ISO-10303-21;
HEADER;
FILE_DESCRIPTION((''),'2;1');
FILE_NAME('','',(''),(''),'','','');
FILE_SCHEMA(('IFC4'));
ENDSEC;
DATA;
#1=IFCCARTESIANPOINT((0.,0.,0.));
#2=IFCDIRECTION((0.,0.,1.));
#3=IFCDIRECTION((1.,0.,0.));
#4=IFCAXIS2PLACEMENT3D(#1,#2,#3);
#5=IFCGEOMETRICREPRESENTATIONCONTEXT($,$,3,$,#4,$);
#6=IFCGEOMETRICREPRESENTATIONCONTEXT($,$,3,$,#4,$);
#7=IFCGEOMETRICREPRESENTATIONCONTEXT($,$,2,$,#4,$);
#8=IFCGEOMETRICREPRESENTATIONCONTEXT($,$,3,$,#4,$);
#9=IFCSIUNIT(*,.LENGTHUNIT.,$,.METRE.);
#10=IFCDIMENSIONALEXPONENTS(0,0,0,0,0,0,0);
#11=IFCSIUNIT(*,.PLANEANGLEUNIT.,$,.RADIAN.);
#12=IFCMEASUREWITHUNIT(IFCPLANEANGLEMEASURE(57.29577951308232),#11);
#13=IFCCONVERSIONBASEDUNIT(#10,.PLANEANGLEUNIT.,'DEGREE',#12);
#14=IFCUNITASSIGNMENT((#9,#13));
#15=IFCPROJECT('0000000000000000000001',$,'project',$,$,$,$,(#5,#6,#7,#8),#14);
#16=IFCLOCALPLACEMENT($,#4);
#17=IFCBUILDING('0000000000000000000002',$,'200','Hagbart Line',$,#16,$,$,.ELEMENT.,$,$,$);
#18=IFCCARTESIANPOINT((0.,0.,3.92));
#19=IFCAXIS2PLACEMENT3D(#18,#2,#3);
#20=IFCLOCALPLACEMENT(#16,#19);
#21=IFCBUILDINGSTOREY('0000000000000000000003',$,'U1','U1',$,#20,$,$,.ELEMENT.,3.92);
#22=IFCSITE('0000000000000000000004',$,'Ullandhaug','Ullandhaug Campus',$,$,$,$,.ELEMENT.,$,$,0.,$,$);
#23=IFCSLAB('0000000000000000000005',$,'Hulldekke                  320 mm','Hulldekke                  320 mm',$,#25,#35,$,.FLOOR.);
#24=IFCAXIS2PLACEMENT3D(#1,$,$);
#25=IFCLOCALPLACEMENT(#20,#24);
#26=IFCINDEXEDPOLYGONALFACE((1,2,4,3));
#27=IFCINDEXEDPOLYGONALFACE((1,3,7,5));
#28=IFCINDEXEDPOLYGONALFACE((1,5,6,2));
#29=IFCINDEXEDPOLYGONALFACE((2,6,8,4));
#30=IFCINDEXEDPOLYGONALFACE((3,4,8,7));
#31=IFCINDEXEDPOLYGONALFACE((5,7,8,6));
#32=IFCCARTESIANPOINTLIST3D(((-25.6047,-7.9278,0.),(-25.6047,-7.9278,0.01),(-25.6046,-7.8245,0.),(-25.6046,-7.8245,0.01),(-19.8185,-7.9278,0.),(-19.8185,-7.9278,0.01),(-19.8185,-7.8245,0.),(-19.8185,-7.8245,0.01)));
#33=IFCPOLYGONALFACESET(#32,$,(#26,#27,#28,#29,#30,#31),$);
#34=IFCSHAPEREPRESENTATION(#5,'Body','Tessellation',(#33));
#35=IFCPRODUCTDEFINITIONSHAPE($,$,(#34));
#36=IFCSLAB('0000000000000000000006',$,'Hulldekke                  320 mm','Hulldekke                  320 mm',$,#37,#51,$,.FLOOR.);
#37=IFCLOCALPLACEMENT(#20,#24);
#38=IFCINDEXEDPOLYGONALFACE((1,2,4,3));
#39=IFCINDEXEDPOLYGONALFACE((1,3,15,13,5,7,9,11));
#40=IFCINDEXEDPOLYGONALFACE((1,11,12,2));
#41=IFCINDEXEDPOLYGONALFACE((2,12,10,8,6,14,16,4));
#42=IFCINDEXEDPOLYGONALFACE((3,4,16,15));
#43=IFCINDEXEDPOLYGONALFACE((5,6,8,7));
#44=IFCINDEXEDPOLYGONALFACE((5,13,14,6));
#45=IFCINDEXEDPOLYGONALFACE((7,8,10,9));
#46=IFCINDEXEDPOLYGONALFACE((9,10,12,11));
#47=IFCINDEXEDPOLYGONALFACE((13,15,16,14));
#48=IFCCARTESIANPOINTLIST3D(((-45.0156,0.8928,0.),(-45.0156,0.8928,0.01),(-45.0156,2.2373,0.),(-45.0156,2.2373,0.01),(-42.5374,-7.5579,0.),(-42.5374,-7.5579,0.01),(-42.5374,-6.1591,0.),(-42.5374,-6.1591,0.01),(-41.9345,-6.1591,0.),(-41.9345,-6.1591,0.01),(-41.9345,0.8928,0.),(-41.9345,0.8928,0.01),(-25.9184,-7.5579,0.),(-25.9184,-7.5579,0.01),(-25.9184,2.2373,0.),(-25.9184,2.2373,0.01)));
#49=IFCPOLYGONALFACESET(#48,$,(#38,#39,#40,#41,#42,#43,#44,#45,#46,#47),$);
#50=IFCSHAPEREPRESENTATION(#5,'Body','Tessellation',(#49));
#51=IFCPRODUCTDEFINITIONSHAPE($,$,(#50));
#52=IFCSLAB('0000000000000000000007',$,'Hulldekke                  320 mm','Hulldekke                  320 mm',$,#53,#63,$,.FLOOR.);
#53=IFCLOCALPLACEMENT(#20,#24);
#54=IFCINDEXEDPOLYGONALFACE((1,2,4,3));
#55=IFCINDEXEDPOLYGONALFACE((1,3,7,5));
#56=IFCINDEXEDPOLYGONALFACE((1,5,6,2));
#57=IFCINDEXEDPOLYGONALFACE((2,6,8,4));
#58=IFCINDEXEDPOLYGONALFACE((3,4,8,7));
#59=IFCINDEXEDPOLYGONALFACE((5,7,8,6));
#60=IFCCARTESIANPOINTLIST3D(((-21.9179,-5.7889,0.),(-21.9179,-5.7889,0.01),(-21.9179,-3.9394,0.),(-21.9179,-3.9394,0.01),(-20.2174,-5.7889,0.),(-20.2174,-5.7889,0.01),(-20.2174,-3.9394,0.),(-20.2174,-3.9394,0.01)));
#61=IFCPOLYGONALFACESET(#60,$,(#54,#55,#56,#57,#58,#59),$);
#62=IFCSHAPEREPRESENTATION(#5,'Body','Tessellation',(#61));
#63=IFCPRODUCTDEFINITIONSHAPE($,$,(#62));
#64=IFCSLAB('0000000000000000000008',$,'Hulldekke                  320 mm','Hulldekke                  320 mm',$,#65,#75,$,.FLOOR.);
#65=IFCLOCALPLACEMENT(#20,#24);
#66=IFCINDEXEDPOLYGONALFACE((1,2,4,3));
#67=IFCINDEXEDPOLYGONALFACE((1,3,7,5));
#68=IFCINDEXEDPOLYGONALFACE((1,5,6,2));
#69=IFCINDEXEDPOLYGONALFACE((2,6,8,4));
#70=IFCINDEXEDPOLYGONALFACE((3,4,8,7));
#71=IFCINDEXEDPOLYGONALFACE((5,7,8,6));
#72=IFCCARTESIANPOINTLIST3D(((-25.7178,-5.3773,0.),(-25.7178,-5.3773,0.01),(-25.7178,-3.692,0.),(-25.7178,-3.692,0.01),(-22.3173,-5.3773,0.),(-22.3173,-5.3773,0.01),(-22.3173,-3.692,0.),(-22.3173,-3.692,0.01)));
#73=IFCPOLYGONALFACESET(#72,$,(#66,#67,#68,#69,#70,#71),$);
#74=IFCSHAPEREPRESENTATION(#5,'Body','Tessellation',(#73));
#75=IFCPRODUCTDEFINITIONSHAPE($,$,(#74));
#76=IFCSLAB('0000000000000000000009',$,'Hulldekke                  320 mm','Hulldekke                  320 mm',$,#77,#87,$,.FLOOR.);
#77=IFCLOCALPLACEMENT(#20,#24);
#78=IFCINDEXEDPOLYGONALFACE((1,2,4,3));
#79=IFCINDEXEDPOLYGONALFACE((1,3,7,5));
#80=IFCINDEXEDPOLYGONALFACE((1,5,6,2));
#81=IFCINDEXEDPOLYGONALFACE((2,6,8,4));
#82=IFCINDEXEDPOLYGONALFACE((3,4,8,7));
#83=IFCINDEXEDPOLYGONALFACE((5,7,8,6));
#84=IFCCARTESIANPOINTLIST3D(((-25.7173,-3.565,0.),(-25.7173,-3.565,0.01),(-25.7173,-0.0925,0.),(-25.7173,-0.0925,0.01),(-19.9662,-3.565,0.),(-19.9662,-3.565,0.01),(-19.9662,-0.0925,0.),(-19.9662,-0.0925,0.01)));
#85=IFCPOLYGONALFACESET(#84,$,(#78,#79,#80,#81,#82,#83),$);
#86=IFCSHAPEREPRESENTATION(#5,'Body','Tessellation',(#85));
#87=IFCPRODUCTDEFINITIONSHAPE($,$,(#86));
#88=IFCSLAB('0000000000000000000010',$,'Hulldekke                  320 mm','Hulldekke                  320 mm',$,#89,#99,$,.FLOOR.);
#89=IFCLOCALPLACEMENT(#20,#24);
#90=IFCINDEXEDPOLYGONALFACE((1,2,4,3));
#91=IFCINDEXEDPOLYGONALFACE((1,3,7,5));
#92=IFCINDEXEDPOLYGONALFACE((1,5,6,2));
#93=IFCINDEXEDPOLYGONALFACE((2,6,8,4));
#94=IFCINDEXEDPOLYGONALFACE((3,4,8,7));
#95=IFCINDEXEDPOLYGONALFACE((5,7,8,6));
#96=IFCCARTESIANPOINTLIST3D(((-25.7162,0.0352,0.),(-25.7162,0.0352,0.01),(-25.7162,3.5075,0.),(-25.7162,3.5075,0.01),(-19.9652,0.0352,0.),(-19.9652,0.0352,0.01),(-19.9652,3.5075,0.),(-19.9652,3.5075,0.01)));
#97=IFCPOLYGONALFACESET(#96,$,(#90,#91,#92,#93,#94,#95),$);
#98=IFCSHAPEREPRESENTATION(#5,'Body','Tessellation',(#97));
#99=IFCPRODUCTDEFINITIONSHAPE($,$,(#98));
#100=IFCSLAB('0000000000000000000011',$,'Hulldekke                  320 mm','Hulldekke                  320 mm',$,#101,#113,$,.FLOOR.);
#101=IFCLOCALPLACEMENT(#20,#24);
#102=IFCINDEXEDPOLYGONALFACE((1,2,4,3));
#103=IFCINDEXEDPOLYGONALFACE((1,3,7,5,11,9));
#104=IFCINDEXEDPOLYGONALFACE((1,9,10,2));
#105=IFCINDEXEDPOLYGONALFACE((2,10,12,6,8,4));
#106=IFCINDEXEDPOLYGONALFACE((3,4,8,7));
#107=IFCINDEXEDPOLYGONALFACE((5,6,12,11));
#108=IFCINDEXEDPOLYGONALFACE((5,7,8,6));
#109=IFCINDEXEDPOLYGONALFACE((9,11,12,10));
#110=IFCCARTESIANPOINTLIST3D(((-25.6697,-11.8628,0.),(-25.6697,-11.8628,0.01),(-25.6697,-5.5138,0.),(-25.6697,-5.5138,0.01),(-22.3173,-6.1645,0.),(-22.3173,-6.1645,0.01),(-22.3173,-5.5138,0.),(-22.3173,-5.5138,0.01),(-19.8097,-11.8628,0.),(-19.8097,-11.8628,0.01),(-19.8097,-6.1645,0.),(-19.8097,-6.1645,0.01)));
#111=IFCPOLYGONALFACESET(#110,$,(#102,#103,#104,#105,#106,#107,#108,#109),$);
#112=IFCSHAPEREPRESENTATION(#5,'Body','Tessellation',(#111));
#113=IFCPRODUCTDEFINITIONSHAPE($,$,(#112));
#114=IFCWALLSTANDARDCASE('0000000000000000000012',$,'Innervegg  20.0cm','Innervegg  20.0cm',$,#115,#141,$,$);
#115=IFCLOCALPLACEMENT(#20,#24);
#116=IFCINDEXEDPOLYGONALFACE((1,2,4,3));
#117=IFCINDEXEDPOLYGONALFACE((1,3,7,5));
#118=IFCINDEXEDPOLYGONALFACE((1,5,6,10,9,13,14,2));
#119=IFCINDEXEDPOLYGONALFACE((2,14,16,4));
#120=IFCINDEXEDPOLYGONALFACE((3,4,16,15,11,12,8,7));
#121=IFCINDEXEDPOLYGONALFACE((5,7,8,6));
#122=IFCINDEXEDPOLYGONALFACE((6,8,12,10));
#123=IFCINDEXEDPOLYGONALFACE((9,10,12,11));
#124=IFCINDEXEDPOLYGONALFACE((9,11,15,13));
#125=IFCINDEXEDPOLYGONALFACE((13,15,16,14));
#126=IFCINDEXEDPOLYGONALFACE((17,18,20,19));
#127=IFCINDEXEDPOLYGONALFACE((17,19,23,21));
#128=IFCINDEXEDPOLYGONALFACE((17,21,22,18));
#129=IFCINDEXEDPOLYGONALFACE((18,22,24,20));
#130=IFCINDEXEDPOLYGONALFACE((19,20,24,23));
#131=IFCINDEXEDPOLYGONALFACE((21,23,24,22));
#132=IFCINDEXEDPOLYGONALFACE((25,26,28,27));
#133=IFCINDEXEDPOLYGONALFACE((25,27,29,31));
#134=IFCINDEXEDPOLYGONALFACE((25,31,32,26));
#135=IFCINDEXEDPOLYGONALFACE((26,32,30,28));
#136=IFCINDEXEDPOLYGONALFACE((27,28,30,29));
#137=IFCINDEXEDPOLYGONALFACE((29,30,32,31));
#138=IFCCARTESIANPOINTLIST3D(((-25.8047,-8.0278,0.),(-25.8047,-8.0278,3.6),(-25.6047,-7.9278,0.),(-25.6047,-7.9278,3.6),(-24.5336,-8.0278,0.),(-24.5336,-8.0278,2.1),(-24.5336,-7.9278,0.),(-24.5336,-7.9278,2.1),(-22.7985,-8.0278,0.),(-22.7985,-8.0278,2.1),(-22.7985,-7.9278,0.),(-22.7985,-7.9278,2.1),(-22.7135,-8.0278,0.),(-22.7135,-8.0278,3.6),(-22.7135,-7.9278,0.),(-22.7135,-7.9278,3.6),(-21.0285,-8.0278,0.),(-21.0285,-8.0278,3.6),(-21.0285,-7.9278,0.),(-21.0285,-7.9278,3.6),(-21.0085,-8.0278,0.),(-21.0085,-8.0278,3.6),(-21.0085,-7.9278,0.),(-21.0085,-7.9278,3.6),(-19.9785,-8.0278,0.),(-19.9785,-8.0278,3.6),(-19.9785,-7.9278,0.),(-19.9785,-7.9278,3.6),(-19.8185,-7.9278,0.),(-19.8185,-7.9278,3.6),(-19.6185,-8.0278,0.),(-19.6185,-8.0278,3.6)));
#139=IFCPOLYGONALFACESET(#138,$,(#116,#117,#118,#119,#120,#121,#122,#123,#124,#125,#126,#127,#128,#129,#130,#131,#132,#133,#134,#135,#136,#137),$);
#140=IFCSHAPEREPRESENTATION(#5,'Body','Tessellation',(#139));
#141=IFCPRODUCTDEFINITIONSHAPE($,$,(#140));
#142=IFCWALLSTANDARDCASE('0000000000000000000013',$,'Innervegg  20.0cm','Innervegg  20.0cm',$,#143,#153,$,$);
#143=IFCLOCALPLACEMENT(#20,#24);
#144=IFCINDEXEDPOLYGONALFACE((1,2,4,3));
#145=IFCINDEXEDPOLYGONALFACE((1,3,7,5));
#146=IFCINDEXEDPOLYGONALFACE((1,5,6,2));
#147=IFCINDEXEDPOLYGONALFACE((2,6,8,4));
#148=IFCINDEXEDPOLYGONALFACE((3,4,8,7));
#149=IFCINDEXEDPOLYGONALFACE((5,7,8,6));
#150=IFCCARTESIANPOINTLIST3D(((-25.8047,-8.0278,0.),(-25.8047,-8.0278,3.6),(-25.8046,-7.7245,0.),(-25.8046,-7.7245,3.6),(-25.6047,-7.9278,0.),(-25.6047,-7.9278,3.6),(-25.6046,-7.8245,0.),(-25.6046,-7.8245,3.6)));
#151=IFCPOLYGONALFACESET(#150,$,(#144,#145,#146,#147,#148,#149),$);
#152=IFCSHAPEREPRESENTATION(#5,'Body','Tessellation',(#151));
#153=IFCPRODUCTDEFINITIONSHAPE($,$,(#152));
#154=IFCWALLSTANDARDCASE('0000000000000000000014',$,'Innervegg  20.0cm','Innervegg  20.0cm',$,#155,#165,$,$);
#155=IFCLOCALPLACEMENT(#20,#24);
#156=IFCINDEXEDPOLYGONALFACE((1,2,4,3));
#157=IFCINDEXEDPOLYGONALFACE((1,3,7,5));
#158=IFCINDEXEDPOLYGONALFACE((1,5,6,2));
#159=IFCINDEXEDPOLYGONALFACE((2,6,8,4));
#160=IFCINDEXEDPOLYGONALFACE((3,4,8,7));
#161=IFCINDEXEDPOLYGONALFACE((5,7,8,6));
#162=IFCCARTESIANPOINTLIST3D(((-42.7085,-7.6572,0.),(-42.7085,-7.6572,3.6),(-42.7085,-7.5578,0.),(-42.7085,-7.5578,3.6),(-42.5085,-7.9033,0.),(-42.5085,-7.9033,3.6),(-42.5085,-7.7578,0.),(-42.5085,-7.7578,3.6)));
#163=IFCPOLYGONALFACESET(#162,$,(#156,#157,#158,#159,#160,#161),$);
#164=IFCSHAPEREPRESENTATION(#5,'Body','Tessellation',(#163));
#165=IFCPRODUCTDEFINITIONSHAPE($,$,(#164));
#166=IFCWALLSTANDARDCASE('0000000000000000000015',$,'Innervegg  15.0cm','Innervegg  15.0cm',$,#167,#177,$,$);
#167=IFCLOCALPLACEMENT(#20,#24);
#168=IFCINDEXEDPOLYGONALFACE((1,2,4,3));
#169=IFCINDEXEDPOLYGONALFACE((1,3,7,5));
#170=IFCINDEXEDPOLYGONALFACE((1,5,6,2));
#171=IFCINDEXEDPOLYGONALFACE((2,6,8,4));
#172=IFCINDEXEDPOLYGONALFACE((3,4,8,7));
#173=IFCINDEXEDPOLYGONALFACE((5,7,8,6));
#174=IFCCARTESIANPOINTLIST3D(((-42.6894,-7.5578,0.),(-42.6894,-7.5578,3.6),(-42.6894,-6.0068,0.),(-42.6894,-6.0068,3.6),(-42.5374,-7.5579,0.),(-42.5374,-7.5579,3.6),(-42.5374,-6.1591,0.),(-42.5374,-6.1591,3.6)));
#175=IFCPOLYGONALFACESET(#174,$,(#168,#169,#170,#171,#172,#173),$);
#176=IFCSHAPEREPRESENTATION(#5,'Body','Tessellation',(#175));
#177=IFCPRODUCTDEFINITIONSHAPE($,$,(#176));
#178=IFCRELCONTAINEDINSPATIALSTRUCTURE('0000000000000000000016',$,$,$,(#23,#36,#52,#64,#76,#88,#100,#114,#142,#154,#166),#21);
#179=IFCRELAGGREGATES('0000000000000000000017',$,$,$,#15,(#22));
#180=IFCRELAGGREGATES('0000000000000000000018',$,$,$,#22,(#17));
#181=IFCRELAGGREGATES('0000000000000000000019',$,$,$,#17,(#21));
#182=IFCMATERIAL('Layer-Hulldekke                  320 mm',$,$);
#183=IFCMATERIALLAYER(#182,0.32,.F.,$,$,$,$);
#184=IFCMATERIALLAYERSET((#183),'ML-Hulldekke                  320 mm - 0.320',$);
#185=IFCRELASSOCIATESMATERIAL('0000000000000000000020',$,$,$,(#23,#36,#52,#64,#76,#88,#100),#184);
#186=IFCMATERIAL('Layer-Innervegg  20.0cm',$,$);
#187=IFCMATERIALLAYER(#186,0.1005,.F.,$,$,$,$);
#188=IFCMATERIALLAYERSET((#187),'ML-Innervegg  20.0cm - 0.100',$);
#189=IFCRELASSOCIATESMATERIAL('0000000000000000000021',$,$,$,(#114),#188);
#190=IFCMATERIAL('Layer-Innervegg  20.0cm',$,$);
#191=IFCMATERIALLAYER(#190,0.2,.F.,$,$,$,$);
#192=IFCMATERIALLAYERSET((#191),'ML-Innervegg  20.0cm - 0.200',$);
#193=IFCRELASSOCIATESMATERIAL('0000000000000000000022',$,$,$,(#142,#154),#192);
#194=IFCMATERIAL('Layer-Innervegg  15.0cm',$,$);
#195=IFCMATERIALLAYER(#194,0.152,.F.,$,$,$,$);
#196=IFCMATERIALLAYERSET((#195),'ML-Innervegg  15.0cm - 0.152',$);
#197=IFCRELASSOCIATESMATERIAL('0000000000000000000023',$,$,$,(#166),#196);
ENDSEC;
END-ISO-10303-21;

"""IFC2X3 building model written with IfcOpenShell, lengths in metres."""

from ifc_helpers import new_model, entity, si_unit, converted_unit, frame, origin_with_axes, place, context, project, spatial, polyline, outline, extrude, material, layer, layer_set, layer_usage, element, save


model = new_model("IFC2X3")

# Units and contexts
context_of_model_1 = context(None, 3, world=origin_with_axes())
context_of_model_2 = context(None, 3, world=origin_with_axes())
context_of_model_3 = context(None, 2, world=origin_with_axes())
context_of_model_4 = context(None, 3, world=origin_with_axes())
ifc_project = project(units=[si_unit("LENGTHUNIT", "METRE"), converted_unit("PLANEANGLEUNIT", "DEGREE", entity("IfcPlaneAngleMeasure", 57.29577951308232), si_unit("PLANEANGLEUNIT", "RADIAN"), dimensions=[0, 0, 0, 0, 0, 0, 0])], contexts=[context_of_model_1, context_of_model_2, context_of_model_3, context_of_model_4])

# Site, building, storey
site = spatial("IfcSite", under=ifc_project, Name="Ullandhaug", Description="Ullandhaug Campus", CompositionType="ELEMENT", RefElevation=0.0)
building_placement = place(None, origin_with_axes())
building = spatial("IfcBuilding", under=site, at=building_placement, Name="200", Description="Hagbart Line", CompositionType="ELEMENT")
storey_placement = place(building_placement, frame((0.0, 0.0, 3.92), z_axis=(0.0, 0.0, 1.0), x_axis=(1.0, 0.0, 0.0)))
storey = spatial("IfcBuildingStorey", under=building, at=storey_placement, Name="U1", Description="U1", CompositionType="ELEMENT", Elevation=3.92)

# Slabs
ifc_material_1 = material(Name="Layer-Hulldekke                  320 mm")
ifc_layer_1 = layer(ifc_material_1, 0.32, ventilated=False)
ifc_layer_set_1 = layer_set([ifc_layer_1], Name="ML-Hulldekke                  320 mm - 0.320")
ifc_layer_usage_1 = layer_usage(ifc_layer_set_1, "AXIS2", "POSITIVE", 0.0)
slab_1_placement = place(storey_placement, frame((-25.6047, -7.9278, 0.0), z_axis=(0.0, 0.0, 1.0), x_axis=(1.0, 0.0, 0.0)))
element("IfcSlab", 1, at=slab_1_placement, inside=storey, material=ifc_layer_usage_1, Name="Hulldekke                  320 mm", Description="Hulldekke                  320 mm", PredefinedType="FLOOR", context=context_of_model_1, shape_type="SweptSolid", body=[
    extrude(outline(polyline([(0.0, 0.0), (5.7861, 0.0), (5.7861, 0.1033), (0.0, 0.1033), (0.0, 0.0)])), origin_with_axes(), (0.0, 0.0, 1.0), 0.01),
])
slab_2_placement = place(storey_placement, frame((-42.5374, -7.5579, 0.0), z_axis=(0.0, 0.0, 1.0), x_axis=(1.0, 0.0, 0.0)))
element("IfcSlab", 2, at=slab_2_placement, inside=storey, material=ifc_layer_usage_1, Name="Hulldekke                  320 mm", Description="Hulldekke                  320 mm", PredefinedType="FLOOR", context=context_of_model_1, shape_type="SweptSolid", body=[
    extrude(outline(polyline([(0.0, 0.0), (16.619, 0.0), (16.619, 9.7952), (-2.4781, 9.7952), (-2.4781, 8.4507), (0.603, 8.4507), (0.603, 1.3988), (0.0, 1.3988), (0.0, 0.0)])), origin_with_axes(), (0.0, 0.0, 1.0), 0.01),
])
slab_3_placement = place(storey_placement, frame((-21.9179, -5.7889, 0.0), z_axis=(0.0, 0.0, 1.0), x_axis=(1.0, 0.0, 0.0)))
element("IfcSlab", 3, at=slab_3_placement, inside=storey, material=ifc_layer_usage_1, Name="Hulldekke                  320 mm", Description="Hulldekke                  320 mm", PredefinedType="FLOOR", context=context_of_model_1, shape_type="SweptSolid", body=[
    extrude(outline(polyline([(0.0, 0.0), (1.7005, 0.0), (1.7005, 1.8495), (0.0, 1.8495), (0.0, 0.0)])), origin_with_axes(), (0.0, 0.0, 1.0), 0.01),
])
slab_4_placement = place(storey_placement, frame((-25.7178, -5.3773, 0.0), z_axis=(0.0, 0.0, 1.0), x_axis=(1.0, 0.0, 0.0)))
element("IfcSlab", 4, at=slab_4_placement, inside=storey, material=ifc_layer_usage_1, Name="Hulldekke                  320 mm", Description="Hulldekke                  320 mm", PredefinedType="FLOOR", context=context_of_model_1, shape_type="SweptSolid", body=[
    extrude(outline(polyline([(0.0, 0.0), (3.4005, 0.0), (3.4005, 1.6853), (0.0, 1.6853), (0.0, 0.0)])), origin_with_axes(), (0.0, 0.0, 1.0), 0.01),
])
slab_5_placement = place(storey_placement, frame((-25.7173, -3.565, 0.0), z_axis=(0.0, 0.0, 1.0), x_axis=(1.0, 0.0, 0.0)))
element("IfcSlab", 5, at=slab_5_placement, inside=storey, material=ifc_layer_usage_1, Name="Hulldekke                  320 mm", Description="Hulldekke                  320 mm", PredefinedType="FLOOR", context=context_of_model_1, shape_type="SweptSolid", body=[
    extrude(outline(polyline([(0.0, 0.0), (5.751, 0.0), (5.751, 3.4726), (0.0, 3.4726), (0.0, 0.0)])), origin_with_axes(), (0.0, 0.0, 1.0), 0.01),
])
slab_6_placement = place(storey_placement, frame((-25.7162, 0.0352, 0.0), z_axis=(0.0, 0.0, 1.0), x_axis=(1.0, 0.0, 0.0)))
element("IfcSlab", 6, at=slab_6_placement, inside=storey, material=ifc_layer_usage_1, Name="Hulldekke                  320 mm", Description="Hulldekke                  320 mm", PredefinedType="FLOOR", context=context_of_model_1, shape_type="SweptSolid", body=[
    extrude(outline(polyline([(0.0, 0.0), (5.751, 0.0), (5.751, 3.4723), (0.0, 3.4723), (0.0, 0.0)])), origin_with_axes(), (0.0, 0.0, 1.0), 0.01),
])
slab_7_placement = place(storey_placement, frame((-25.6697, -11.8628, 0.0), z_axis=(0.0, 0.0, 1.0), x_axis=(1.0, 0.0, 0.0)))
element("IfcSlab", 7, at=slab_7_placement, inside=storey, material=ifc_layer_usage_1, Name="Hulldekke                  320 mm", Description="Hulldekke                  320 mm", PredefinedType="FLOOR", context=context_of_model_1, shape_type="SweptSolid", body=[
    extrude(outline(polyline([(0.0, 0.0), (5.86, 0.0), (5.86, 5.6983), (3.3524, 5.6983), (3.3524, 6.349), (0.0, 6.349), (0.0, 0.0)])), origin_with_axes(), (0.0, 0.0, 1.0), 0.01),
])

# Wall, openings
ifc_material_2 = material(Name="Layer-Innervegg  20.0cm")
ifc_layer_2 = layer(ifc_material_2, 0.1005, ventilated=False)
ifc_layer_set_2 = layer_set([ifc_layer_2], Name="ML-Innervegg  20.0cm - 0.100")
ifc_layer_usage_2 = layer_usage(ifc_layer_set_2, "AXIS2", "POSITIVE", 0.0)
wall_1_placement = place(storey_placement, frame((-25.8047, -8.0278, 0.0), z_axis=(0.0, 0.0, 1.0), x_axis=(1.0, 0.0, 0.0)))
wall_1 = element("IfcWallStandardCase", 8, at=wall_1_placement, inside=storey, material=ifc_layer_usage_2, Name="Innervegg  20.0cm", Description="Innervegg  20.0cm", context=context_of_model_1, shape_type="SweptSolid", body=[
    extrude(outline(polyline([(0.0, 0.0), (6.1862, 0.0), (5.9862, 0.1), (0.2, 0.1), (0.0, 0.0)])), origin_with_axes(), (0.0, 0.0, 1.0), 3.6),
])
opening_1_placement = place(wall_1_placement, frame((1.2711, 0.1, 0.0), z_axis=(0.0, 0.0, 1.0), x_axis=(1.0, 0.0, 0.0)))
element("IfcOpeningElement", 9, at=opening_1_placement, cuts=wall_1, context=context_of_model_1, shape_type="SweptSolid", body=[
    extrude(outline(polyline([(0.0, 0.0), (2.1, 0.0), (2.1, 1.735), (0.0, 1.735), (0.0, 0.0)])), frame((0.0, 0.0, 0.0), z_axis=(0.0, 1.0, 0.0), x_axis=(0.0, 0.0, 1.0)), (0.0, 0.0, -1.0), 0.1),
])
opening_2_placement = place(wall_1_placement, frame((4.7962, 0.1, 0.0), z_axis=(0.0, 0.0, 1.0), x_axis=(1.0, 0.0, 0.0)))
element("IfcOpeningElement", 10, at=opening_2_placement, cuts=wall_1, context=context_of_model_1, shape_type="SweptSolid", body=[
    extrude(outline(polyline([(0.0, 0.0), (3.6, 0.0), (3.6, 1.03), (0.0, 1.03), (0.0, 0.0)])), frame((0.0, 0.0, 0.0), z_axis=(0.0, 1.0, 0.0), x_axis=(0.0, 0.0, 1.0)), (0.0, 0.0, -1.0), 0.1),
])
opening_3_placement = place(wall_1_placement, frame((3.0912, 0.1, 0.0), z_axis=(0.0, 0.0, 1.0), x_axis=(1.0, 0.0, 0.0)))
element("IfcOpeningElement", 11, at=opening_3_placement, cuts=wall_1, context=context_of_model_1, shape_type="SweptSolid", body=[
    extrude(outline(polyline([(0.0, 0.0), (3.6, 0.0), (3.6, 1.685), (0.0, 1.685), (0.0, 0.0)])), frame((0.0, 0.0, 0.0), z_axis=(0.0, 1.0, 0.0), x_axis=(0.0, 0.0, 1.0)), (0.0, 0.0, -1.0), 0.1),
])

# Walls
ifc_material_3 = material(Name="Layer-Innervegg  20.0cm")
ifc_layer_3 = layer(ifc_material_3, 0.2, ventilated=False)
ifc_layer_set_3 = layer_set([ifc_layer_3], Name="ML-Innervegg  20.0cm - 0.200")
ifc_layer_usage_3 = layer_usage(ifc_layer_set_3, "AXIS2", "POSITIVE", 0.0)
wall_2_placement = place(storey_placement, frame((-25.8046, -7.7245, 0.0), z_axis=(0.0, 0.0, 1.0), x_axis=(-0.000296, -1.0, 0.0)))
element("IfcWallStandardCase", 12, at=wall_2_placement, inside=storey, material=ifc_layer_usage_3, Name="Innervegg  20.0cm", Description="Innervegg  20.0cm", context=context_of_model_1, shape_type="SweptSolid", body=[
    extrude(outline(polyline([(0.0, 0.0), (0.3033, 0.0), (0.2033, 0.2), (0.0999, 0.2), (0.0, 0.0)])), frame((0.0, 0.0, 0.0), z_axis=(0.0, 0.0, 1.0), x_axis=(1.0, 0.0, 0.0)), (0.0, 0.0, 1.0), 3.6),
])
wall_3_placement = place(storey_placement, frame((-42.5085, -7.9033, 0.0), z_axis=(0.0, 0.0, 1.0), x_axis=(0.0, 1.0, 0.0)))
element("IfcWallStandardCase", 13, at=wall_3_placement, inside=storey, material=ifc_layer_usage_3, Name="Innervegg  20.0cm", Description="Innervegg  20.0cm", context=context_of_model_1, shape_type="SweptSolid", body=[
    extrude(outline(polyline([(0.0, 0.0), (0.1454, 0.0), (0.3454, 0.2), (0.2461, 0.2), (0.0, 0.0)])), frame((0.0, 0.0, 0.0), z_axis=(0.0, 0.0, 1.0), x_axis=(1.0, 0.0, 0.0)), (0.0, 0.0, 1.0), 3.6),
])
ifc_material_4 = material(Name="Layer-Innervegg  15.0cm")
ifc_layer_4 = layer(ifc_material_4, 0.152, ventilated=False)
ifc_layer_set_4 = layer_set([ifc_layer_4], Name="ML-Innervegg  15.0cm - 0.152")
ifc_layer_usage_4 = layer_usage(ifc_layer_set_4, "AXIS2", "POSITIVE", 0.0)
wall_4_placement = place(storey_placement, frame((-42.5374, -7.5579, 0.0), z_axis=(0.0, 0.0, 1.0), x_axis=(0.0, 1.0, 0.0)))
element("IfcWallStandardCase", 14, at=wall_4_placement, inside=storey, material=ifc_layer_usage_4, Name="Innervegg  15.0cm", Description="Innervegg  15.0cm", context=context_of_model_1, shape_type="SweptSolid", body=[
    extrude(outline(polyline([(0.0, 0.0), (1.3988, 0.0), (1.551, 0.152), (0.0001, 0.152), (0.0, 0.0)])), frame((0.0, 0.0, 0.0), z_axis=(0.0, 0.0, 1.0), x_axis=(1.0, 0.0, 0.0)), (0.0, 0.0, 1.0), 3.6),
])

save(model, "model.ifc")
